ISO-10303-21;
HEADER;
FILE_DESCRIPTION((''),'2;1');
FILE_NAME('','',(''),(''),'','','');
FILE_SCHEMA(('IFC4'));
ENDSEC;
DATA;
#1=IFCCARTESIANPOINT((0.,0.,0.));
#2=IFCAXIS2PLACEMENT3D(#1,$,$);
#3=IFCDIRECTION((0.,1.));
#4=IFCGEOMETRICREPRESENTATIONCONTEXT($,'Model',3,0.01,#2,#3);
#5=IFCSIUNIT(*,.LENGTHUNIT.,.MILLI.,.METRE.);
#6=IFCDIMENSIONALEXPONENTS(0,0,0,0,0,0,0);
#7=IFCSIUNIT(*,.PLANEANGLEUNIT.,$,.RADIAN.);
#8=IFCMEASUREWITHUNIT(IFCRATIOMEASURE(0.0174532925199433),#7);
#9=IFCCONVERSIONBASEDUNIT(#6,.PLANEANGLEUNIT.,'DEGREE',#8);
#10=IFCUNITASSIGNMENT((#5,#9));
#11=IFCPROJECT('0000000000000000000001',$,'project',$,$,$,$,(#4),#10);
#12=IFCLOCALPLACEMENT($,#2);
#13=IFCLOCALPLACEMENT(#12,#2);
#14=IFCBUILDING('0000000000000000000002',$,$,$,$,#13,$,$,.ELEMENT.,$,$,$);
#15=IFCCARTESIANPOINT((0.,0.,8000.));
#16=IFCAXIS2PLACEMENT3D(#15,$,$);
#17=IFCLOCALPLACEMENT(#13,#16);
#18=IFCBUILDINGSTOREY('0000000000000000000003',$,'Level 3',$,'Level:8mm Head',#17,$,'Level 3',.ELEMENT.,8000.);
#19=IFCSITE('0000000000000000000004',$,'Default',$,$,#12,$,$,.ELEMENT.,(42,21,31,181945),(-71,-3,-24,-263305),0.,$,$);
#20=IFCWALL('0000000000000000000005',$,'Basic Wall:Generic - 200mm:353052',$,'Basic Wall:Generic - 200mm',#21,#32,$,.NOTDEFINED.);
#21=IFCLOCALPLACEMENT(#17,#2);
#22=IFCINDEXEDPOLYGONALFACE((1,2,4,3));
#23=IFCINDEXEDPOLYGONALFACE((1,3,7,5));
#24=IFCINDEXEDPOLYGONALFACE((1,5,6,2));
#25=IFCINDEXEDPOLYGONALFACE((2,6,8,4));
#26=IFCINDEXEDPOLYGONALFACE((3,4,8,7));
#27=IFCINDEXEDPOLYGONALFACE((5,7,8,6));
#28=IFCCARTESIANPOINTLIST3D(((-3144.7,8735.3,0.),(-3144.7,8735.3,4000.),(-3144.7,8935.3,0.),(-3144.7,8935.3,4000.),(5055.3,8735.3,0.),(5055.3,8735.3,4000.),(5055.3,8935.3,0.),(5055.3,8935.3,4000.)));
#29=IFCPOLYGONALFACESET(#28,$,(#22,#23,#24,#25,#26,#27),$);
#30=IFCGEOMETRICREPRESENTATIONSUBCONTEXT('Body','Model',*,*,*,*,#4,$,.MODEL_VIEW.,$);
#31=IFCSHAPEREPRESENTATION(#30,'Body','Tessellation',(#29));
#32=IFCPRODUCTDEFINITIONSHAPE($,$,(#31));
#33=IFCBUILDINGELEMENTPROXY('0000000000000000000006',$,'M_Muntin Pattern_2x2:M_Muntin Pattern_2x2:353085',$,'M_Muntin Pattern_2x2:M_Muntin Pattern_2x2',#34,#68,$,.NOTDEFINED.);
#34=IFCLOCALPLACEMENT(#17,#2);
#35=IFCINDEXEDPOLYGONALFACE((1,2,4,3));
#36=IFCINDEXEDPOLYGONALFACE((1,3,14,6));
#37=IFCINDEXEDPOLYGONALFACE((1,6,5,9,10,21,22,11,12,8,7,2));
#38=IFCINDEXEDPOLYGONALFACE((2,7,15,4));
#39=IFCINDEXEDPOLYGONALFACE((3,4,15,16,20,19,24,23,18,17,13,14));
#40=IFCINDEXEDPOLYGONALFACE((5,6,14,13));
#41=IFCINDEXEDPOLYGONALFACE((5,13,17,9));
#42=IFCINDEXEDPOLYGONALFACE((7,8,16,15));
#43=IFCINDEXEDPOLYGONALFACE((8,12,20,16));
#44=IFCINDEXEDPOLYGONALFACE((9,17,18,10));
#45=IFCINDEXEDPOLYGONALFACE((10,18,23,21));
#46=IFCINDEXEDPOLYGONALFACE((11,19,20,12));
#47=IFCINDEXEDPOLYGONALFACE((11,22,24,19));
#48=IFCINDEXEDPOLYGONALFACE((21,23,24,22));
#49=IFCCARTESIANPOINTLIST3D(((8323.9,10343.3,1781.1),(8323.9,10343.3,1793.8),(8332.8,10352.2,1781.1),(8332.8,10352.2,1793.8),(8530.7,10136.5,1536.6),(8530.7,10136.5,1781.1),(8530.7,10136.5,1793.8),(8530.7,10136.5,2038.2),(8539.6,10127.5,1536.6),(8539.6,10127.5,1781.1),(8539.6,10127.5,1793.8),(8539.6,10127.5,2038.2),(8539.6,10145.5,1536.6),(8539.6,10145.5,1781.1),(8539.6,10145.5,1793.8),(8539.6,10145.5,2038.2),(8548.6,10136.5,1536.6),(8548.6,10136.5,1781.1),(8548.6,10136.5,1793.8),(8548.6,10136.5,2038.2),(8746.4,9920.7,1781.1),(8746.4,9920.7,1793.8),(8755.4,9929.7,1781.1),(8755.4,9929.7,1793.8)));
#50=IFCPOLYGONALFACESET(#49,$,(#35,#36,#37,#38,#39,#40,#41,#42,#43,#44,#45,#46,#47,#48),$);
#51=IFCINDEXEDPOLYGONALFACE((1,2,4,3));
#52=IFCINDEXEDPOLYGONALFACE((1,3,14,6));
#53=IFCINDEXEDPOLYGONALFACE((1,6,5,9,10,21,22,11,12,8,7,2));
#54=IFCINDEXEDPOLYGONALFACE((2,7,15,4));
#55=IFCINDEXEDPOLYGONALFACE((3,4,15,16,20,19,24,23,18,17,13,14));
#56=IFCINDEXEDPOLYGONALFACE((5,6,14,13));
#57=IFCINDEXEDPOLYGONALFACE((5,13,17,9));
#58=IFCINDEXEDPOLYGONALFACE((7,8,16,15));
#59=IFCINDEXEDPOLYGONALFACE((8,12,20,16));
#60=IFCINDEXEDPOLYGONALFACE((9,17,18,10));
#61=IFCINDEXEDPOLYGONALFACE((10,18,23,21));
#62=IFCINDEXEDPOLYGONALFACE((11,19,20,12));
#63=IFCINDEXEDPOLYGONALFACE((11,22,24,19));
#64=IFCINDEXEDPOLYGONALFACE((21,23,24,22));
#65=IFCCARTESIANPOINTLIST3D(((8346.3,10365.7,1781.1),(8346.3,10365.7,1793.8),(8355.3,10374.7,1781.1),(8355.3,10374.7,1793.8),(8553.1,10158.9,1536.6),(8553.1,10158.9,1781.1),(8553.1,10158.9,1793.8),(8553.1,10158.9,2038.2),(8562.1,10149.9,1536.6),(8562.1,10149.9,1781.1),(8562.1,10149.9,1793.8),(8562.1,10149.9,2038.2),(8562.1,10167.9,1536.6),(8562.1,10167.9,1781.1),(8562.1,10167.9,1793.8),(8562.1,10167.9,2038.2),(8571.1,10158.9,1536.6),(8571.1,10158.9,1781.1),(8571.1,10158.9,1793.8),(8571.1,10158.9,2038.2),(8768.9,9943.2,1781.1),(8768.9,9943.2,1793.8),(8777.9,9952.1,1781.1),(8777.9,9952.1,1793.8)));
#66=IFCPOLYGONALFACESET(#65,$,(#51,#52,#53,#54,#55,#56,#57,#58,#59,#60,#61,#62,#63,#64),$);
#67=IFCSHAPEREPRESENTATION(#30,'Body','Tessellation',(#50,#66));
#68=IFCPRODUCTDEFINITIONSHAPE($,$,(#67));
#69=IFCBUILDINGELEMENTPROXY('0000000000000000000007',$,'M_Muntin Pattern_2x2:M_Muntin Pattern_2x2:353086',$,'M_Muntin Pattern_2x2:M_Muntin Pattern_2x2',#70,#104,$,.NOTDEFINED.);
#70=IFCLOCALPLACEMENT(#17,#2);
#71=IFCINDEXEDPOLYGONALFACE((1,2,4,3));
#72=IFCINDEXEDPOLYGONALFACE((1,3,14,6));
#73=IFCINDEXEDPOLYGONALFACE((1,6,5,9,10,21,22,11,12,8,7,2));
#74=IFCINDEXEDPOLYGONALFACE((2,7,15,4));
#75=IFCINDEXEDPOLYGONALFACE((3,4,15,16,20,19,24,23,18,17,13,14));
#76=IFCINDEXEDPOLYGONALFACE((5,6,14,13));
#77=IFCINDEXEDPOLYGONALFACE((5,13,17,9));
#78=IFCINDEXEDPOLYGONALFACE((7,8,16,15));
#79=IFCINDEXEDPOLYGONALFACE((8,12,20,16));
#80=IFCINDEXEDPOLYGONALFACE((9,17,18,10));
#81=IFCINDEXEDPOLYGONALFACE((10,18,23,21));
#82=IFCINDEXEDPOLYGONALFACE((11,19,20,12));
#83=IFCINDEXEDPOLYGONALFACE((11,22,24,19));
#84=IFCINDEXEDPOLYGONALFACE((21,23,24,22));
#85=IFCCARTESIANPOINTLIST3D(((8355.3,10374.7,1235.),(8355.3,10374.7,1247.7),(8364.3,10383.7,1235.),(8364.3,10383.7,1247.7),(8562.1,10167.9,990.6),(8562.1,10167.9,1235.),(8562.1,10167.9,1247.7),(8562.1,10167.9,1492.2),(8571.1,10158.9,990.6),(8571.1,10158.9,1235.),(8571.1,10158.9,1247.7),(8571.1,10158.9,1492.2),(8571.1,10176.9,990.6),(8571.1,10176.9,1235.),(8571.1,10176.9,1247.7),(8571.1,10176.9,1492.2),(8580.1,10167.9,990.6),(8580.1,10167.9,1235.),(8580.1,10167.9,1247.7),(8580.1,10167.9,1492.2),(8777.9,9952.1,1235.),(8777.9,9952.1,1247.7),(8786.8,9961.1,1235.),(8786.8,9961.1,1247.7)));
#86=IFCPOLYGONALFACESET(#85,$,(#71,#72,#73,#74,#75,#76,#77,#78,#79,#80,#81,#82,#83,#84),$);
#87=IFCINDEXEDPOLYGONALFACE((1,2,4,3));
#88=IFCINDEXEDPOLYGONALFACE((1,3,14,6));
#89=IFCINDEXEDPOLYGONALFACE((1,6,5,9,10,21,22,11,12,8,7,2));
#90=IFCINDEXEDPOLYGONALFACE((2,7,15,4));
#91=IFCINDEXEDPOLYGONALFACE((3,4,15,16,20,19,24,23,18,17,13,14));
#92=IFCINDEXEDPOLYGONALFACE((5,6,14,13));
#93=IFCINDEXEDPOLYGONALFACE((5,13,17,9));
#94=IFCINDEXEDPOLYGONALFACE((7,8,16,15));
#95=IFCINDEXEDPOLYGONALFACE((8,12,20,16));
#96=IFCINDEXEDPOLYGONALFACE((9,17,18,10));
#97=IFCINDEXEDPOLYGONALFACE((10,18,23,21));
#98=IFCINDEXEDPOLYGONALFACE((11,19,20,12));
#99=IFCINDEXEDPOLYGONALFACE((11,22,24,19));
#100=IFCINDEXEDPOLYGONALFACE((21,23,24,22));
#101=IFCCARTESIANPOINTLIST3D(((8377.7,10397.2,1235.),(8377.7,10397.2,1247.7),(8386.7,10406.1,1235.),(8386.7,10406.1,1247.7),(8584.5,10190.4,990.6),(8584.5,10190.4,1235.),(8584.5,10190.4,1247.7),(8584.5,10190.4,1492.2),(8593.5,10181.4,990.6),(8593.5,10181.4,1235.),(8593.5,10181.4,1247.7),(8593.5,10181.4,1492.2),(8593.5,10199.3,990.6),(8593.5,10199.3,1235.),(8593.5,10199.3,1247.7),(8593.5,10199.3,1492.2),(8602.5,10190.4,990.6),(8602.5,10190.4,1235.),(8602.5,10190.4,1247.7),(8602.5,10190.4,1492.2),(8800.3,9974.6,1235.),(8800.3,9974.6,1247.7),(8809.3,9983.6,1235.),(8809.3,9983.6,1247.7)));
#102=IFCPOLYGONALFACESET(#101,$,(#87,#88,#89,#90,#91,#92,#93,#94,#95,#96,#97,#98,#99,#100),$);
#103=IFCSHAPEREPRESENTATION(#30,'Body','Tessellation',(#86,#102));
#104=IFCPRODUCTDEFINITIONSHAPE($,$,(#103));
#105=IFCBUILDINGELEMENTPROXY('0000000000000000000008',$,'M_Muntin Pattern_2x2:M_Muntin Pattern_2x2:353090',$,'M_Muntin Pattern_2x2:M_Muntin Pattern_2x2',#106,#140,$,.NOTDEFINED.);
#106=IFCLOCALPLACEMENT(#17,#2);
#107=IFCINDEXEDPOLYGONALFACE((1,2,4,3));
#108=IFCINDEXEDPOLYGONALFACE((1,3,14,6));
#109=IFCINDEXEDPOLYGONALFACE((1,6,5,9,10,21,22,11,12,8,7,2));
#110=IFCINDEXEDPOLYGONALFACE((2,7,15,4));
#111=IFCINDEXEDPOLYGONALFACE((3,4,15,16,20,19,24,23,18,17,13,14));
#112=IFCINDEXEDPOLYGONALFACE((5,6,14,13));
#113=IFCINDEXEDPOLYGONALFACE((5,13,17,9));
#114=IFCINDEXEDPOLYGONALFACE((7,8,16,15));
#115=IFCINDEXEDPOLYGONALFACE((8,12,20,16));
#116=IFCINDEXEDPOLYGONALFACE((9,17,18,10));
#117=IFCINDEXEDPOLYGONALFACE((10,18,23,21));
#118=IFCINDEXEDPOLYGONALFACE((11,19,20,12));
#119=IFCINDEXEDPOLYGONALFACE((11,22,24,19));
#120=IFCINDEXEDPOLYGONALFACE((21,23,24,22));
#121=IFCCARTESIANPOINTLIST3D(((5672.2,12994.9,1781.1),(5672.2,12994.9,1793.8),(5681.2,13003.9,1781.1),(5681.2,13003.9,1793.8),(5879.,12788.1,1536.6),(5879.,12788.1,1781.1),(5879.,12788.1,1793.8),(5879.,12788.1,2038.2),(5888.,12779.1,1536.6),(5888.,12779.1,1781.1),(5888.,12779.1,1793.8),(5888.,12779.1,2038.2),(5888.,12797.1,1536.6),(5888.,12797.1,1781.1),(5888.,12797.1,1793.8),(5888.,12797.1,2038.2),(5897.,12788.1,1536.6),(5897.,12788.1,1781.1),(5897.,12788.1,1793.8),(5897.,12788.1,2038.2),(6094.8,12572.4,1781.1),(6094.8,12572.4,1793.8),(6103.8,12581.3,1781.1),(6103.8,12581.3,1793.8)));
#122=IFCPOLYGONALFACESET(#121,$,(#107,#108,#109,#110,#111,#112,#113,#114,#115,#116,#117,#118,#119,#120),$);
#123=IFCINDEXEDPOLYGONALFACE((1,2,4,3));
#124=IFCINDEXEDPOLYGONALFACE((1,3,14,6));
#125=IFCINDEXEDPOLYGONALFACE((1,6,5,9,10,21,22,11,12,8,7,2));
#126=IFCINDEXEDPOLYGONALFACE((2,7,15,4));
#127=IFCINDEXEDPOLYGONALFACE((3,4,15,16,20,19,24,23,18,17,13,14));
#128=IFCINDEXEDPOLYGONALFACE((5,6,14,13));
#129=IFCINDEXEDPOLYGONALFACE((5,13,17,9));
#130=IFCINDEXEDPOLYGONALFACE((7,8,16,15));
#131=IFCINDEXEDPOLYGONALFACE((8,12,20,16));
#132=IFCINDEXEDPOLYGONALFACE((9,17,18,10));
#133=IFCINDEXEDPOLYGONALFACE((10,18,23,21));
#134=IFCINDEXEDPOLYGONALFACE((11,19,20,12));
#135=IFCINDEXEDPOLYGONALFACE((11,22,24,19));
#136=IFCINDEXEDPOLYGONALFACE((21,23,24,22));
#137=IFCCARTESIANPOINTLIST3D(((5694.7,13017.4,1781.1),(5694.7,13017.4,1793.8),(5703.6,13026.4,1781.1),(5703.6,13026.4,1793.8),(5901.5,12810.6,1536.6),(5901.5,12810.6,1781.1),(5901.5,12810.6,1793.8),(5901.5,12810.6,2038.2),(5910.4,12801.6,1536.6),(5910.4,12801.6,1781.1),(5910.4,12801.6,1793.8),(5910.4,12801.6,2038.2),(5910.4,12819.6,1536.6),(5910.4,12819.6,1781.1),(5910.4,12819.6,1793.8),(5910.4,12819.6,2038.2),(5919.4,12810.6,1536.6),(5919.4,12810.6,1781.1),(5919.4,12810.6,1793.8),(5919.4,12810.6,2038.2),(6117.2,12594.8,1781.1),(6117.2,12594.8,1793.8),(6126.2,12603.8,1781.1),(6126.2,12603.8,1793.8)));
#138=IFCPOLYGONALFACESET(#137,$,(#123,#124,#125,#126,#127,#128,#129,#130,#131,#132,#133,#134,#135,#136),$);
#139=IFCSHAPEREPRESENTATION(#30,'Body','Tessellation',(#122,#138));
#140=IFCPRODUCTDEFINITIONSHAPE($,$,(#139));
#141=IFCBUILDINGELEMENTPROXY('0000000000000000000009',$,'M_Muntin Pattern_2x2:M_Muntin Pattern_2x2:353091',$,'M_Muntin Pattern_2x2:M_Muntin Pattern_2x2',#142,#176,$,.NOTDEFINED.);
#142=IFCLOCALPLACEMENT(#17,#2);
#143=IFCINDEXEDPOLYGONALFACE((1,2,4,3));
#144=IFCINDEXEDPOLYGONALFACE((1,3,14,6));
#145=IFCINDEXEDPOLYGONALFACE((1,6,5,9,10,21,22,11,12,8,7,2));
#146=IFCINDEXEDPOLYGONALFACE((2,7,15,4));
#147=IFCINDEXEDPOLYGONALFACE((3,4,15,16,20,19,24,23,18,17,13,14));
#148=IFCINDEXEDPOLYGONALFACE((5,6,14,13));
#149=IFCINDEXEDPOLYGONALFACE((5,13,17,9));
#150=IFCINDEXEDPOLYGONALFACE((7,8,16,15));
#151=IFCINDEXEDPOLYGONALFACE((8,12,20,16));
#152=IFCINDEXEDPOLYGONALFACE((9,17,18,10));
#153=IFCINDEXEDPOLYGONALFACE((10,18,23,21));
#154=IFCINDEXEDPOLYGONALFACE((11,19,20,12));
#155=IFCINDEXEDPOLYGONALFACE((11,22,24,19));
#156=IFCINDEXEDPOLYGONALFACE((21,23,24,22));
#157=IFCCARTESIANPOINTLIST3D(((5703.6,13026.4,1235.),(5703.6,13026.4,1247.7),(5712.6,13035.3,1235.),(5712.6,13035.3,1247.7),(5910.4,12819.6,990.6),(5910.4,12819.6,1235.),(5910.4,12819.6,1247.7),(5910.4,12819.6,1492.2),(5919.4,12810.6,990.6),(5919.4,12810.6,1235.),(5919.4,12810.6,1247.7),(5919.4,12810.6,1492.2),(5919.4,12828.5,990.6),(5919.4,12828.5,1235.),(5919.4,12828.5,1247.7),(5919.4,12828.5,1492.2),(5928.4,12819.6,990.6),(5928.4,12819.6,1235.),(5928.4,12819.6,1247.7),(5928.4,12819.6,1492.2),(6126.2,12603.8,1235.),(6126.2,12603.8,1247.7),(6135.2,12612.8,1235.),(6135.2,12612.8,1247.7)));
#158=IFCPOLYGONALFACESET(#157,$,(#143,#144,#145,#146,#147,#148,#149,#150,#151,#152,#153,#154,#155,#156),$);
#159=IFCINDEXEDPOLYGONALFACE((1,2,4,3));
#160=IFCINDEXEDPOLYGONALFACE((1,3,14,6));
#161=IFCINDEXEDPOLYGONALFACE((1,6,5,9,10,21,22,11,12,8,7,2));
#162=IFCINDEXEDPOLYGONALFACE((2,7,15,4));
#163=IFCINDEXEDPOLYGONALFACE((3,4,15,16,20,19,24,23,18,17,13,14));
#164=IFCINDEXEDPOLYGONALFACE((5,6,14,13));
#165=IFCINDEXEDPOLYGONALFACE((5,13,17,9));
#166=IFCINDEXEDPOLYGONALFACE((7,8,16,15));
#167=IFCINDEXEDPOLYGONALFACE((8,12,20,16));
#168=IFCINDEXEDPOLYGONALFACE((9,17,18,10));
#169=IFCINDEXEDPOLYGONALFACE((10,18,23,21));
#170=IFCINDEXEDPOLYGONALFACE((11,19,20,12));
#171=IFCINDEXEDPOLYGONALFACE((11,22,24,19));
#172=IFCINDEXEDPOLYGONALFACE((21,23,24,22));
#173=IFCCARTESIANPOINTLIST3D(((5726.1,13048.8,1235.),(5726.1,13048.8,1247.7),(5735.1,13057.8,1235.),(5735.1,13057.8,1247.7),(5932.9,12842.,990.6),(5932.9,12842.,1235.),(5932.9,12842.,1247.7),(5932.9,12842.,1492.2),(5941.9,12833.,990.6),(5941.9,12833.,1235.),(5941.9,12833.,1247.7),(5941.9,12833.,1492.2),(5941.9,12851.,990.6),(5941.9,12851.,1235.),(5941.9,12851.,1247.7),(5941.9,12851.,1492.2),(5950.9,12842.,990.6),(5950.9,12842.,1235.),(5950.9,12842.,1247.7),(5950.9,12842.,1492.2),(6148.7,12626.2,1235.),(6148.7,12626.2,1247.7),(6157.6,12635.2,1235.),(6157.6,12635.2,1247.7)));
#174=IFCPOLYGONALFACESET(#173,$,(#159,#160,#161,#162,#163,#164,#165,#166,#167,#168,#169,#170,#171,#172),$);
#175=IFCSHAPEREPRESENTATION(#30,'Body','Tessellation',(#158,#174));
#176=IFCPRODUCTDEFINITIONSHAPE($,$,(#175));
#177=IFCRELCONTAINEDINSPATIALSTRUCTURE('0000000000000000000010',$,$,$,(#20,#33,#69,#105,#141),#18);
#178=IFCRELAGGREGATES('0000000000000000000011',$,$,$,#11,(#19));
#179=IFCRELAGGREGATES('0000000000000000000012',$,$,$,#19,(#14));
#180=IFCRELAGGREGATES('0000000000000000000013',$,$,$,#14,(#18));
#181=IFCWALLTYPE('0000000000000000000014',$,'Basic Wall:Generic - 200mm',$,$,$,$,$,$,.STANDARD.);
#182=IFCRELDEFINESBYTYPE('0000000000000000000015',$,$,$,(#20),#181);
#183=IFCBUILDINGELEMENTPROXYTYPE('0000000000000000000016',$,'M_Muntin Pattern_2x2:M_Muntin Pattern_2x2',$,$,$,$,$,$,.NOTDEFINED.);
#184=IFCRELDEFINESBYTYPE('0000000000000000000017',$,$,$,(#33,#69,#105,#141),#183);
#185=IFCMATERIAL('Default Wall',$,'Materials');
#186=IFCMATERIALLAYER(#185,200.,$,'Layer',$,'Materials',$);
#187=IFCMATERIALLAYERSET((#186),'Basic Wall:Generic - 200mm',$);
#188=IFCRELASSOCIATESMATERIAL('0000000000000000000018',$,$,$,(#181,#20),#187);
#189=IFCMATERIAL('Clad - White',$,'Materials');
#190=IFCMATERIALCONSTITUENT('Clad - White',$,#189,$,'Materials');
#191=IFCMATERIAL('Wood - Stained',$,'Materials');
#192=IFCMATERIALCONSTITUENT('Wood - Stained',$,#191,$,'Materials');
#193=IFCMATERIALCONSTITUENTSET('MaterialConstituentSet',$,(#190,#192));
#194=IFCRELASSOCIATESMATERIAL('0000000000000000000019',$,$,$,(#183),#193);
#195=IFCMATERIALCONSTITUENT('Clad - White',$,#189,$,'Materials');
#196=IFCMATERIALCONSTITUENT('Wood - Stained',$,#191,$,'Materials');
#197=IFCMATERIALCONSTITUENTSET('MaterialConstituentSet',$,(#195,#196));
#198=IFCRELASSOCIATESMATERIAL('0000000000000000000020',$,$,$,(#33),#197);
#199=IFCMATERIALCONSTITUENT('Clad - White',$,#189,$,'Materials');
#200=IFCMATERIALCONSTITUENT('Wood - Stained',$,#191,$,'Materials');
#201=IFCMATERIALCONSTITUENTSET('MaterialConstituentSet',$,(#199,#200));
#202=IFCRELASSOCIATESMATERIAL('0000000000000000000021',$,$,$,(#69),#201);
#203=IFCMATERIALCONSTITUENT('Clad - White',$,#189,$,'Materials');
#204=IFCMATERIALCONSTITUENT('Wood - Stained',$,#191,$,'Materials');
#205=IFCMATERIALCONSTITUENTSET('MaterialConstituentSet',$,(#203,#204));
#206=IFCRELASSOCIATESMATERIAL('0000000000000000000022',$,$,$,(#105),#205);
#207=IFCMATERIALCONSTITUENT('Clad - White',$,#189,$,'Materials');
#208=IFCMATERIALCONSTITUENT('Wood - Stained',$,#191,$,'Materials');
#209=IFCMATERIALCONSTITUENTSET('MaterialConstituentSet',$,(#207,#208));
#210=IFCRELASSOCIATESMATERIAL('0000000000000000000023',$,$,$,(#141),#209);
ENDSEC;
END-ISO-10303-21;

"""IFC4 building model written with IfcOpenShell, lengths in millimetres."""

from ifc_helpers import new_model, entity, si_unit, converted_unit, direction, frame, frame_2d, origin, place, context, subcontext, project, spatial, polyline, rectangle, outline, extrude, source, transform, mapped, material, layer, layer_set, layer_usage, constituent, constituent_set, type_object, type_shapes, element, save


model = new_model("IFC4")

# Units and contexts
model_context = context("Model", 3, precision=0.01, world=origin(), true_north=direction((0.0, 1.0)))
body_context = subcontext(model_context, "Body", "Model", "MODEL_VIEW")
ifc_project = project(units=[si_unit("LENGTHUNIT", "METRE", prefix="MILLI"), converted_unit("PLANEANGLEUNIT", "DEGREE", entity("IfcRatioMeasure", 0.0174532925199433), si_unit("PLANEANGLEUNIT", "RADIAN"), dimensions=[0, 0, 0, 0, 0, 0, 0])], contexts=[model_context])

# Site, building, storey
site_placement = place(None, origin())
site = spatial("IfcSite", under=ifc_project, at=site_placement, Name="Default", CompositionType="ELEMENT", RefLatitude=(42, 21, 31, 181945), RefLongitude=(-71, -3, -24, -263305), RefElevation=0.0)
building_placement = place(site_placement, origin())
building = spatial("IfcBuilding", under=site, at=building_placement, CompositionType="ELEMENT")
storey_placement = place(building_placement, frame((0.0, 0.0, 8000.0)))
storey = spatial("IfcBuildingStorey", under=building, at=storey_placement, Name="Level 3", ObjectType="Level:8mm Head", LongName="Level 3", CompositionType="ELEMENT", Elevation=8000.0)

# Shared definitions
ifc_material_1 = material(Name="Default Wall", Category="Materials")
ifc_layer = layer(ifc_material_1, 200.0, Name="Layer", Category="Materials")
ifc_layer_set = layer_set([ifc_layer], Name="Basic Wall:Generic - 200mm")
wall_type = type_object("IfcWallType", Name="Basic Wall:Generic - 200mm", PredefinedType="STANDARD", material=ifc_layer_set)
ifc_material_2 = material(Name="Wood - Stained", Category="Materials")

# Wall
ifc_layer_usage_1 = layer_usage(ifc_layer_set, "AXIS2", "NEGATIVE", 100.0)
wall_1_placement = place(storey_placement, frame((5055.3, 8835.3, 0.0), z_axis=(0.0, 0.0, 1.0), x_axis=(-1.0, 0.0, 0.0)))
element("IfcWall", 1, at=wall_1_placement, inside=storey, type_object=wall_type, material=ifc_layer_usage_1, Name="Basic Wall:Generic - 200mm:353052", ObjectType="Basic Wall:Generic - 200mm", PredefinedType="NOTDEFINED", context=body_context, shape_type="SweptSolid", body=[
    extrude(rectangle(XDim=8200.0, YDim=200.0, at=frame_2d((4100.0, 0.0), x_axis=(-1.0, 0.0))), origin(), (0.0, 0.0, 1.0), 4000.0),
])

# Building element proxies
ifc_material_3 = material(Name="Clad - White", Category="Materials")
ifc_constituent_1 = constituent(ifc_material_3, Name="Clad - White", Category="Materials")
ifc_constituent_2 = constituent(ifc_material_2, Name="Wood - Stained", Category="Materials")
ifc_constituent_set_1 = constituent_set(constituents=[ifc_constituent_1, ifc_constituent_2], Name="MaterialConstituentSet")
ifc_constituent_3 = constituent(ifc_material_3, Name="Clad - White", Category="Materials")
ifc_constituent_4 = constituent(ifc_material_2, Name="Wood - Stained", Category="Materials")
ifc_constituent_set_2 = constituent_set(constituents=[ifc_constituent_3, ifc_constituent_4], Name="MaterialConstituentSet")
building_element_proxy_type_1 = type_object("IfcBuildingElementProxyType", Name="M_Muntin Pattern_2x2:M_Muntin Pattern_2x2", PredefinedType="NOTDEFINED", material=ifc_constituent_set_2)
shared_shape_1 = source(origin(), body_context, "Body", "SweptSolid", [
    extrude(outline(polyline([(6.4, -6.4), (250.8, -6.4), (250.8, 6.3), (6.4, 6.3), (6.4, 298.8), (-6.3, 298.8), (-6.3, 6.3), (-250.8, 6.3), (-250.8, -6.4), (-6.3, -6.4), (-6.3, -298.8), (6.4, -298.8), (6.4, -6.4)])), frame((0.0, 9.5, 250.8), z_axis=(0.0, 1.0, 0.0), x_axis=(0.0, 0.0, 1.0)), (0.0, 0.0, 1.0), 12.7),
    extrude(outline(polyline([(6.4, -6.4), (250.8, -6.4), (250.8, 6.3), (6.4, 6.3), (6.4, 298.8), (-6.3, 298.8), (-6.3, 6.3), (-250.8, 6.3), (-250.8, -6.4), (-6.3, -6.4), (-6.3, -298.8), (6.4, -298.8), (6.4, -6.4)])), frame((0.0, -22.2, 250.8), z_axis=(0.0, 1.0, 0.0), x_axis=(0.0, 0.0, 1.0)), (0.0, 0.0, 1.0), 12.7),
])
type_shapes(building_element_proxy_type_1, [shared_shape_1])
proxy_1_placement = place(storey_placement, frame((8550.9, 10147.7, 1536.6), z_axis=(0.0, 0.0, 1.0), x_axis=(-0.707107, 0.707107, 0.0)))
element("IfcBuildingElementProxy", 2, at=proxy_1_placement, inside=storey, type_object=building_element_proxy_type_1, material=ifc_constituent_set_1, Name="M_Muntin Pattern_2x2:M_Muntin Pattern_2x2:353085", ObjectType="M_Muntin Pattern_2x2:M_Muntin Pattern_2x2", PredefinedType="NOTDEFINED", context=body_context, shape_type="MappedRepresentation", body=[
    mapped(shared_shape_1, transform((0.0, 0.0, 0.0), scale=1.0)),
])
ifc_constituent_5 = constituent(ifc_material_3, Name="Clad - White", Category="Materials")
ifc_constituent_6 = constituent(ifc_material_2, Name="Wood - Stained", Category="Materials")
ifc_constituent_set_3 = constituent_set(constituents=[ifc_constituent_5, ifc_constituent_6], Name="MaterialConstituentSet")
proxy_2_placement = place(storey_placement, frame((8582.3, 10179.1, 990.6), z_axis=(0.0, 0.0, 1.0), x_axis=(-0.707107, 0.707107, 0.0)))
element("IfcBuildingElementProxy", 3, at=proxy_2_placement, inside=storey, type_object=building_element_proxy_type_1, material=ifc_constituent_set_3, Name="M_Muntin Pattern_2x2:M_Muntin Pattern_2x2:353086", ObjectType="M_Muntin Pattern_2x2:M_Muntin Pattern_2x2", PredefinedType="NOTDEFINED", context=body_context, shape_type="MappedRepresentation", body=[
    mapped(shared_shape_1, transform((0.0, 0.0, 0.0), scale=1.0)),
])
ifc_constituent_7 = constituent(ifc_material_3, Name="Clad - White", Category="Materials")
ifc_constituent_8 = constituent(ifc_material_2, Name="Wood - Stained", Category="Materials")
ifc_constituent_set_4 = constituent_set(constituents=[ifc_constituent_7, ifc_constituent_8], Name="MaterialConstituentSet")
proxy_3_placement = place(storey_placement, frame((5899.2, 12799.4, 1536.6), z_axis=(0.0, 0.0, 1.0), x_axis=(-0.707107, 0.707107, 0.0)))
element("IfcBuildingElementProxy", 4, at=proxy_3_placement, inside=storey, type_object=building_element_proxy_type_1, material=ifc_constituent_set_4, Name="M_Muntin Pattern_2x2:M_Muntin Pattern_2x2:353090", ObjectType="M_Muntin Pattern_2x2:M_Muntin Pattern_2x2", PredefinedType="NOTDEFINED", context=body_context, shape_type="MappedRepresentation", body=[
    mapped(shared_shape_1, transform((0.0, 0.0, 0.0), scale=1.0)),
])
ifc_constituent_9 = constituent(ifc_material_3, Name="Clad - White", Category="Materials")
ifc_constituent_10 = constituent(ifc_material_2, Name="Wood - Stained", Category="Materials")
ifc_constituent_set_5 = constituent_set(constituents=[ifc_constituent_9, ifc_constituent_10], Name="MaterialConstituentSet")
proxy_4_placement = place(storey_placement, frame((5930.6, 12830.8, 990.6), z_axis=(0.0, 0.0, 1.0), x_axis=(-0.707107, 0.707107, 0.0)))
element("IfcBuildingElementProxy", 5, at=proxy_4_placement, inside=storey, type_object=building_element_proxy_type_1, material=ifc_constituent_set_5, Name="M_Muntin Pattern_2x2:M_Muntin Pattern_2x2:353091", ObjectType="M_Muntin Pattern_2x2:M_Muntin Pattern_2x2", PredefinedType="NOTDEFINED", context=body_context, shape_type="MappedRepresentation", body=[
    mapped(shared_shape_1, transform((0.0, 0.0, 0.0), scale=1.0)),
])

save(model, "model.ifc")
